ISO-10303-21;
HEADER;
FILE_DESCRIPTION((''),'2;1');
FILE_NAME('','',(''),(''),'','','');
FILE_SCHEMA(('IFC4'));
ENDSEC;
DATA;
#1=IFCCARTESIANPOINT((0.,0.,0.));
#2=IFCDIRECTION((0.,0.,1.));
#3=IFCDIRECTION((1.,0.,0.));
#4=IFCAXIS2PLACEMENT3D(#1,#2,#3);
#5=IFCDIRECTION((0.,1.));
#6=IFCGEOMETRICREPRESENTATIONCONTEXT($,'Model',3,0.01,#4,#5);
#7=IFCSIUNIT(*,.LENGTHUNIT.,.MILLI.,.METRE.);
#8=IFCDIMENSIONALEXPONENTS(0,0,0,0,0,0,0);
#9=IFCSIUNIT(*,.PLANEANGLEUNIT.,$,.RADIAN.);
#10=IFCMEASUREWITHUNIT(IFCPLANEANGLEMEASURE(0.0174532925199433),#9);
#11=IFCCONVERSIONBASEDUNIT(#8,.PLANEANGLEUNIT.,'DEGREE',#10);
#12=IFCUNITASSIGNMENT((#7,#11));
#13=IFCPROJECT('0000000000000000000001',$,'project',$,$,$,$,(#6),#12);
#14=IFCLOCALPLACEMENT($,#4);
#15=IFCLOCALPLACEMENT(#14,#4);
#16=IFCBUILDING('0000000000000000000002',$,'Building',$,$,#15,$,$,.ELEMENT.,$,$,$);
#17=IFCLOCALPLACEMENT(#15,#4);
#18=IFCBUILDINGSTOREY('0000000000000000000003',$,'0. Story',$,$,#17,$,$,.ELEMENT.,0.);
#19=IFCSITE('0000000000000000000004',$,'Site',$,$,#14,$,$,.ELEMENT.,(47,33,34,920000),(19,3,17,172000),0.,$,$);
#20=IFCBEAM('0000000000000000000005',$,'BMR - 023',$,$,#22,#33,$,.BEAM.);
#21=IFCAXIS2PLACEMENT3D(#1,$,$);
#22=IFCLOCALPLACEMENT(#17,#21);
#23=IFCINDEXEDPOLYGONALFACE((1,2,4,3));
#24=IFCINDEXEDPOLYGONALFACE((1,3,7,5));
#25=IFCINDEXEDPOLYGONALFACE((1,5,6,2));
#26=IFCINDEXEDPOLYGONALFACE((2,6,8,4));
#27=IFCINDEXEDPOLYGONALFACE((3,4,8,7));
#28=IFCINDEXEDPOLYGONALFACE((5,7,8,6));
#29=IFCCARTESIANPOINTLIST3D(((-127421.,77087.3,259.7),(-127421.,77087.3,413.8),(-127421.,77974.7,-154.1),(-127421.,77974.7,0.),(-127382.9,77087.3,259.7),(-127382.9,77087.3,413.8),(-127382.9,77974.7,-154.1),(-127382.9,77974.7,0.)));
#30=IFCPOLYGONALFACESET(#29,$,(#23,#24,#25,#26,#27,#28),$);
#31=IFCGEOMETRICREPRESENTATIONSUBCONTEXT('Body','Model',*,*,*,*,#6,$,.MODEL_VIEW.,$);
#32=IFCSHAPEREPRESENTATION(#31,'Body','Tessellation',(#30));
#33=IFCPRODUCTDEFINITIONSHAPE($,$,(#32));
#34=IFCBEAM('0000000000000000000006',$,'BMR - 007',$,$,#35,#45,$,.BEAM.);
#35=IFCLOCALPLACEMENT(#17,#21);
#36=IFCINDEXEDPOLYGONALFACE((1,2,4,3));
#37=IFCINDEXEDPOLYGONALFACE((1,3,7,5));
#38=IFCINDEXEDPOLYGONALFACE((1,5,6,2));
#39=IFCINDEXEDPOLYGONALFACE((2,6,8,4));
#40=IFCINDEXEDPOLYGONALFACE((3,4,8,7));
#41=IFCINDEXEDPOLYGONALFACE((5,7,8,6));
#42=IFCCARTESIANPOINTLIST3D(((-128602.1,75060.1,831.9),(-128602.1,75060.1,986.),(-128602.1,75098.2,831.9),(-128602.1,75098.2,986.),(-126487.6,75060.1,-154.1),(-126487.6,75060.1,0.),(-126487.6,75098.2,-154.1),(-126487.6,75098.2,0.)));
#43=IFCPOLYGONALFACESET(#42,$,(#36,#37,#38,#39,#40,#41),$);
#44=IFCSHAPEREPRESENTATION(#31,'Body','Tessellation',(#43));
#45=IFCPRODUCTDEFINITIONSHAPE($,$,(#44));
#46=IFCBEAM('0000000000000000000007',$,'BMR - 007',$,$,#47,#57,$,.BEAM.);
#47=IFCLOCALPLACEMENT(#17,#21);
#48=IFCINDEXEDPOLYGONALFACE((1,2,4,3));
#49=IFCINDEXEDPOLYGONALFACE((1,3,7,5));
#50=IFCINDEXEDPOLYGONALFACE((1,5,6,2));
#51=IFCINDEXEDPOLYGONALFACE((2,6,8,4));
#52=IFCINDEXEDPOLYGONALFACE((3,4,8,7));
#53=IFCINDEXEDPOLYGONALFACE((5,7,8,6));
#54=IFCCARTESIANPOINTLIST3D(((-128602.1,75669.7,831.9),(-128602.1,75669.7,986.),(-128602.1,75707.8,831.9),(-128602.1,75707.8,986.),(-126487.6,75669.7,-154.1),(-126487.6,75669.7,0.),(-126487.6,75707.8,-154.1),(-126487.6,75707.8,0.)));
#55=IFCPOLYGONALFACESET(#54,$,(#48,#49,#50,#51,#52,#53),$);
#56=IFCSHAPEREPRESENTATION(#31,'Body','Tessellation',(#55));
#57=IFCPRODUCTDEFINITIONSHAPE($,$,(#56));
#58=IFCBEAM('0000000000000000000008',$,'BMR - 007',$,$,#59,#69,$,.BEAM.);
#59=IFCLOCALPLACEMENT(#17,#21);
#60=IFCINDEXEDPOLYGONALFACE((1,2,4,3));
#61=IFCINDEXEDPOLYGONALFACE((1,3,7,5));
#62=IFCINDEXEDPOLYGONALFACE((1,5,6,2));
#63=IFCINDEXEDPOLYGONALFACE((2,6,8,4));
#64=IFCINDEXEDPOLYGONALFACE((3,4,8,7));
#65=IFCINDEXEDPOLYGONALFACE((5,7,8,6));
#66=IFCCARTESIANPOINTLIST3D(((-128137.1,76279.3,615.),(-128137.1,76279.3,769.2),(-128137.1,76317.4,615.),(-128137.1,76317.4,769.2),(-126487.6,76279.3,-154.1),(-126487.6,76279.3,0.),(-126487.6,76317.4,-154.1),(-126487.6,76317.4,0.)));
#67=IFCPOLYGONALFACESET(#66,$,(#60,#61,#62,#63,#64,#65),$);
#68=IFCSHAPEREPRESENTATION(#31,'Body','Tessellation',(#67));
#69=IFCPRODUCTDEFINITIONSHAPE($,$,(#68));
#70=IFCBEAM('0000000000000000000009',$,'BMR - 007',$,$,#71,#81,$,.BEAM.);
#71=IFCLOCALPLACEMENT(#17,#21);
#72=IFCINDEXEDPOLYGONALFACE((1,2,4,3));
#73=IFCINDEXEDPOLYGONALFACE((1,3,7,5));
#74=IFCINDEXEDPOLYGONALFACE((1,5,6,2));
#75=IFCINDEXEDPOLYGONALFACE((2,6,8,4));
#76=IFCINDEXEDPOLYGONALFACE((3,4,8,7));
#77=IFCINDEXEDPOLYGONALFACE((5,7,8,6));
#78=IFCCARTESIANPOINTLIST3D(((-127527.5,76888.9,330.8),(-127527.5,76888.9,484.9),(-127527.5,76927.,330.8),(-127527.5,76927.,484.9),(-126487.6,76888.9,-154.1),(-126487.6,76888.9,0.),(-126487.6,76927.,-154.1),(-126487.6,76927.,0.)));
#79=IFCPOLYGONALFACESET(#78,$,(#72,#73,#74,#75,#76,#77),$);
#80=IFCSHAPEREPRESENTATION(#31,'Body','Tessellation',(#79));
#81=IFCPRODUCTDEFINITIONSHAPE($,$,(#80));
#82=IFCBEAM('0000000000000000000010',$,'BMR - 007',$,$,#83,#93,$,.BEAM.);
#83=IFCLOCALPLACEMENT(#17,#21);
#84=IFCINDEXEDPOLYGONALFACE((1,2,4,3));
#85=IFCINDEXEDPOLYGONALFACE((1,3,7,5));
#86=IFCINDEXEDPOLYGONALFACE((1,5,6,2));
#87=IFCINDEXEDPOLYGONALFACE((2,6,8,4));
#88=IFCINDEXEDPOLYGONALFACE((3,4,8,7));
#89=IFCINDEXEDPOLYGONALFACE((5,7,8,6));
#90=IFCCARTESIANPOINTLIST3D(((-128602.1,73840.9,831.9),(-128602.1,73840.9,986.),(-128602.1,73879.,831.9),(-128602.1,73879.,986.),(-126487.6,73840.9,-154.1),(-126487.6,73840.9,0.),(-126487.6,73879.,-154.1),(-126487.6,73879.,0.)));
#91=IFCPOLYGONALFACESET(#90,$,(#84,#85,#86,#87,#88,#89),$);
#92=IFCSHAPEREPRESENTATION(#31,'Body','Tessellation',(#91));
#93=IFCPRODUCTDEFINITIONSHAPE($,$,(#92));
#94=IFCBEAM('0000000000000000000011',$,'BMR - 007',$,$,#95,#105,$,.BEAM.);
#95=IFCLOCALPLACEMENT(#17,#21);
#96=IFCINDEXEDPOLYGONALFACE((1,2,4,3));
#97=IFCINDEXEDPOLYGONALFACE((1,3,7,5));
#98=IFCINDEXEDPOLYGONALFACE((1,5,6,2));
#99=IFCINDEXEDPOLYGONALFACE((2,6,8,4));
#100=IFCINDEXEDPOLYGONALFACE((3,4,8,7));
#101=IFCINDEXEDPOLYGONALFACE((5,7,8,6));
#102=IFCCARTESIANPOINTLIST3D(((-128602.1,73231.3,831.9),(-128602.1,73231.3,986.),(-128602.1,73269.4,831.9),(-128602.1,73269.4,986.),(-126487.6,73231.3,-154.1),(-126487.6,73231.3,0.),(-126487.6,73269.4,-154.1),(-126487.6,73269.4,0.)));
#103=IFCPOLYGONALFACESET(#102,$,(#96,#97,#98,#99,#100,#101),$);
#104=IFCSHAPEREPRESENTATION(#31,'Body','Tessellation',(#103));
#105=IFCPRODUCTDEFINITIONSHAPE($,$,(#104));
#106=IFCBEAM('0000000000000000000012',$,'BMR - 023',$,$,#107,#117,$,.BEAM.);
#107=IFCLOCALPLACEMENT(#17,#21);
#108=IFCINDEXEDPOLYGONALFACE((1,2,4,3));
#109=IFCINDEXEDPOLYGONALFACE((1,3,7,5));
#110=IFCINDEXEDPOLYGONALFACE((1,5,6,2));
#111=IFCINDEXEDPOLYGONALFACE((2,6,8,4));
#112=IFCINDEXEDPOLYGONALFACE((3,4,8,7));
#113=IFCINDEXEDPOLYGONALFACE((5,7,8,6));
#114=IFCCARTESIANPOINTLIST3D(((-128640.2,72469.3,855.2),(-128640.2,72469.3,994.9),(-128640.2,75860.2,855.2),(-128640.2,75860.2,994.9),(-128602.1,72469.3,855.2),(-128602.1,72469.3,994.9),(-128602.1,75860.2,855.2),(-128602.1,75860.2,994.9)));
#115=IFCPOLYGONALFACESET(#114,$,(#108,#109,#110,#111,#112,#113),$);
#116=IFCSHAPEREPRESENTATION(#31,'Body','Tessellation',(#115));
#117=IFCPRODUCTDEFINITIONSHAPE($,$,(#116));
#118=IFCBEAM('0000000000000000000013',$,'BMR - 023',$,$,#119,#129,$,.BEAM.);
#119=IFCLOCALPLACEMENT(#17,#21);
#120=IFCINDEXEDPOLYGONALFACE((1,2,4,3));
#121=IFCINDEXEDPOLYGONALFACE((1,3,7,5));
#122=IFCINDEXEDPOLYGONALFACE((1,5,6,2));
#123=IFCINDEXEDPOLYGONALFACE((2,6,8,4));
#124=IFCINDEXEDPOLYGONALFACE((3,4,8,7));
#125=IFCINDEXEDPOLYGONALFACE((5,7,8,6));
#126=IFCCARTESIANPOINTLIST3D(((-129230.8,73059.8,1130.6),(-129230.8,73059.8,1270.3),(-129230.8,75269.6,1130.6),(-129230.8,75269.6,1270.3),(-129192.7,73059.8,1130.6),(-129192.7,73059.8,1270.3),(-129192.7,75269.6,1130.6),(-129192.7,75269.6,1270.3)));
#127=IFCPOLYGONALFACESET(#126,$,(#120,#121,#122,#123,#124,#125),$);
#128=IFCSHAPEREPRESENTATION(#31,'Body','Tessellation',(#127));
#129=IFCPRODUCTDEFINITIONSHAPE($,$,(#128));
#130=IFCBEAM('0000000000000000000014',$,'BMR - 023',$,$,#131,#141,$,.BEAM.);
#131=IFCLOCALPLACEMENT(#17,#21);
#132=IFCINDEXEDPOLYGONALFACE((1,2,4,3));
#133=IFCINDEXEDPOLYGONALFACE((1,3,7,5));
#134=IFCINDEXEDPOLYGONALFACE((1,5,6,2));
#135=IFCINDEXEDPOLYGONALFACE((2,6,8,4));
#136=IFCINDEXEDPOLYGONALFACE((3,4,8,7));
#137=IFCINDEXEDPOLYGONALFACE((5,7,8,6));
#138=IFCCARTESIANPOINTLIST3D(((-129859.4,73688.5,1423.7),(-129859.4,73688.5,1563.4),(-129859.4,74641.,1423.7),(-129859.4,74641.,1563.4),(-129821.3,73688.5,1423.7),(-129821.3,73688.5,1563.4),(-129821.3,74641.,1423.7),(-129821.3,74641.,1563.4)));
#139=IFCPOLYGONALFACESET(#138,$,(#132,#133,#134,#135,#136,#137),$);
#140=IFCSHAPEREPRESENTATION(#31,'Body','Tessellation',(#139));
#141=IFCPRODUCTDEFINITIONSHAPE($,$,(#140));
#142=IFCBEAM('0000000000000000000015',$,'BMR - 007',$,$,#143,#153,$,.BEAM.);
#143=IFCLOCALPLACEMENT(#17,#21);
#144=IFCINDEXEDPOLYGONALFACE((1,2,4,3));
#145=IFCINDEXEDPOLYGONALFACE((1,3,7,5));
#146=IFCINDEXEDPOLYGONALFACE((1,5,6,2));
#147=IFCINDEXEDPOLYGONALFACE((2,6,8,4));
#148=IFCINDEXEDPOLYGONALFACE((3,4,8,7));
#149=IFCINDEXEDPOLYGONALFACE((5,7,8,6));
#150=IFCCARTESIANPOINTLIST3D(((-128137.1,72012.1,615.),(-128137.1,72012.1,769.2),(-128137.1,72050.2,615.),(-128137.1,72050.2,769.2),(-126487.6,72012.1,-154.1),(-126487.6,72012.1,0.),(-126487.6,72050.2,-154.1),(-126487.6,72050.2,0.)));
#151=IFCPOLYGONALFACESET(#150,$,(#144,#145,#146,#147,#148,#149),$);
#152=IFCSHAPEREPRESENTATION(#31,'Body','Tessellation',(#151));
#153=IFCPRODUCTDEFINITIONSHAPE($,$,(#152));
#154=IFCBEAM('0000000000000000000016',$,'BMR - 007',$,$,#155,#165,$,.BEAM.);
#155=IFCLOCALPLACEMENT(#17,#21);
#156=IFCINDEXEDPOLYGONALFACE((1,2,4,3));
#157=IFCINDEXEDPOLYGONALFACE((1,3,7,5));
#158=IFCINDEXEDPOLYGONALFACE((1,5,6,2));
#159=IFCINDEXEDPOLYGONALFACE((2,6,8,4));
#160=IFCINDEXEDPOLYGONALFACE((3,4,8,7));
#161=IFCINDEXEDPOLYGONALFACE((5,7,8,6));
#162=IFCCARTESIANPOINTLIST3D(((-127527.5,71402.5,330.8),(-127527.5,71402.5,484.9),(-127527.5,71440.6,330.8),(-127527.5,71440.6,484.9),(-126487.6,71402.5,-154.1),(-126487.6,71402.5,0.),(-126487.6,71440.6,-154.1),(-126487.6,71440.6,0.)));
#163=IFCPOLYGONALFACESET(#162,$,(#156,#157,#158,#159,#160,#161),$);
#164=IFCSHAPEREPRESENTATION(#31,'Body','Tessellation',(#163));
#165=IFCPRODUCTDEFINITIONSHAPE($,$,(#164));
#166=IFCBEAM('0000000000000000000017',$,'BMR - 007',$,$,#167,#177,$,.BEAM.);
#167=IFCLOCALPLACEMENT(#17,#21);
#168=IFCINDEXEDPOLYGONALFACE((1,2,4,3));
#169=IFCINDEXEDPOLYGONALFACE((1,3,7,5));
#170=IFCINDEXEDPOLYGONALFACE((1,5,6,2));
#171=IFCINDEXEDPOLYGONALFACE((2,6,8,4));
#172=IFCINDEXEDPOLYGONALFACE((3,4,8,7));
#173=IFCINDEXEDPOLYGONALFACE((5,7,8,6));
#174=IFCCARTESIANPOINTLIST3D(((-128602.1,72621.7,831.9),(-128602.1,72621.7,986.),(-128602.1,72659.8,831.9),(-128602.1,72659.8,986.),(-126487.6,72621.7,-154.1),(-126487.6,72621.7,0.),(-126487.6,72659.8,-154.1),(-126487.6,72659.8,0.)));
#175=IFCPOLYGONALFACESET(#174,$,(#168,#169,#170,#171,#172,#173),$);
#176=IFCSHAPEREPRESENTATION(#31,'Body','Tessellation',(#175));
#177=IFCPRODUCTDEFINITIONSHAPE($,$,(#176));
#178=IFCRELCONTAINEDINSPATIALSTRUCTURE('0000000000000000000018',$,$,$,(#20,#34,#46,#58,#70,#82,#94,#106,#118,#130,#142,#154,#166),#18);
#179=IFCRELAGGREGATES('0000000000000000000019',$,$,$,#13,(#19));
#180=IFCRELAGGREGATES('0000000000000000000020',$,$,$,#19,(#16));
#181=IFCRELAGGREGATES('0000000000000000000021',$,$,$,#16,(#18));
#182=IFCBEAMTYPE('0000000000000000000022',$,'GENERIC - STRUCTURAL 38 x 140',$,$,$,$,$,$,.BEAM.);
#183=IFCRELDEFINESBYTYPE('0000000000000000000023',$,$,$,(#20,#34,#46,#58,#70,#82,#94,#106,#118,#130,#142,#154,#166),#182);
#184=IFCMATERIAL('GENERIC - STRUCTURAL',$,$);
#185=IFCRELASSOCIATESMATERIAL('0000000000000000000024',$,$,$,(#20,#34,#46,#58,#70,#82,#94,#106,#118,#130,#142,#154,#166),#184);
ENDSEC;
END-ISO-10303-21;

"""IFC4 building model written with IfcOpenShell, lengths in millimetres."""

from ifc_helpers import new_model, entity, si_unit, converted_unit, direction, frame, frame_2d, origin_with_axes, place, context, subcontext, project, spatial, rectangle, extrude, clip, halfspace, material, type_object, element, save


model = new_model("IFC4")

# Units and contexts
model_context = context("Model", 3, precision=0.01, world=origin_with_axes(), true_north=direction((0.0, 1.0)))
body_context = subcontext(model_context, "Body", "Model", "MODEL_VIEW")
ifc_project = project(units=[si_unit("LENGTHUNIT", "METRE", prefix="MILLI"), converted_unit("PLANEANGLEUNIT", "DEGREE", entity("IfcPlaneAngleMeasure", 0.0174532925199433), si_unit("PLANEANGLEUNIT", "RADIAN"), dimensions=[0, 0, 0, 0, 0, 0, 0])], contexts=[model_context])

# Site, building, storey
site_placement = place(None, origin_with_axes())
site = spatial("IfcSite", under=ifc_project, at=site_placement, Name="Site", CompositionType="ELEMENT", RefLatitude=(47, 33, 34, 920000), RefLongitude=(19, 3, 17, 172000), RefElevation=0.0)
building_placement = place(site_placement, origin_with_axes())
building = spatial("IfcBuilding", under=site, at=building_placement, Name="Building", CompositionType="ELEMENT")
storey_placement = place(building_placement, origin_with_axes())
storey = spatial("IfcBuildingStorey", under=building, at=storey_placement, Name="0. Story", CompositionType="ELEMENT", Elevation=0.0)

# Beams
ifc_material = material(Name="GENERIC - STRUCTURAL")
beam_type = type_object("IfcBeamType", Name="GENERIC - STRUCTURAL 38 x 140", PredefinedType="BEAM")
beam_1_placement = place(storey_placement, frame((-127402.0, 77974.7, 0.0), z_axis=(0.0, 0.0, 1.0), x_axis=(-1.0, 0.0, 0.0)))
element("IfcBeam", 1, at=beam_1_placement, inside=storey, type_object=beam_type, material=ifc_material, Name="BMR - 023", PredefinedType="BEAM", context=body_context, shape_type="Clipping", body=[
    clip(clip(extrude(rectangle(XDim=139.7, YDim=38.1, at=frame_2d((-69.8, 0.0), x_axis=(1.0, 0.0))), frame((0.0, -83.5, -38.9), z_axis=(0.0, 0.906308, 0.422618), x_axis=(0.0, -0.422618, 0.906308)), (0.0, 0.0, 1.0), 1163.5), halfspace(frame((0.0, 0.0, 0.0), z_axis=(0.0, 1.0, 0.0), x_axis=(0.0, 0.0, 1.0)), True)), halfspace(frame((0.0, 887.5, 0.0), z_axis=(0.0, -1.0, 0.0), x_axis=(0.0, 0.0, -1.0)), True)),
])
for number, where, z_axis, x_axis, name in (
    (2, (-126487.6, 75079.1, 0.0), (0.0, 0.0, 1.0), (0.0, 1.0, 0.0), "BMR - 007"),
    (3, (-126487.6, 75688.7, 0.0), (0.0, 0.0, 1.0), (0.0, 1.0, 0.0), "BMR - 007"),
):
    element("IfcBeam", number, at=place(storey_placement, frame(where, z_axis=z_axis, x_axis=x_axis)), inside=storey, type_object=beam_type, material=ifc_material, Name=name, PredefinedType="BEAM", context=body_context, shape_type="Clipping", body=[
        clip(clip(extrude(rectangle(XDim=139.7, YDim=38.1, at=frame_2d((-69.8, 0.0), x_axis=(1.0, 0.0))), frame((0.0, -83.5, -38.9), z_axis=(0.0, 0.906308, 0.422618), x_axis=(0.0, -0.422618, 0.906308)), (0.0, 0.0, 1.0), 2517.4), halfspace(frame((0.0, 0.0, 0.0), z_axis=(0.0, 1.0, 0.0), x_axis=(0.0, 0.0, 1.0)), True)), halfspace(frame((0.0, 2114.5, 0.0), z_axis=(0.0, -1.0, 0.0), x_axis=(0.0, 0.0, -1.0)), True)),
    ])
beam_2_placement = place(storey_placement, frame((-126487.6, 76298.3, 0.0), z_axis=(0.0, 0.0, 1.0), x_axis=(0.0, 1.0, 0.0)))
element("IfcBeam", 4, at=beam_2_placement, inside=storey, type_object=beam_type, material=ifc_material, Name="BMR - 007", PredefinedType="BEAM", context=body_context, shape_type="Clipping", body=[
    clip(clip(extrude(rectangle(XDim=139.7, YDim=38.1, at=frame_2d((-69.8, 0.0), x_axis=(1.0, 0.0))), frame((0.0, -83.5, -38.9), z_axis=(0.0, 0.906308, 0.422618), x_axis=(0.0, -0.422618, 0.906308)), (0.0, 0.0, 1.0), 2004.2), halfspace(frame((0.0, 0.0, 0.0), z_axis=(0.0, 1.0, 0.0), x_axis=(0.0, 0.0, 1.0)), True)), halfspace(frame((0.0, 1649.5, 0.0), z_axis=(0.0, -1.0, 0.0), x_axis=(0.0, 0.0, -1.0)), True)),
])
beam_3_placement = place(storey_placement, frame((-126487.6, 76907.9, 0.0), z_axis=(0.0, 0.0, 1.0), x_axis=(0.0, 1.0, 0.0)))
element("IfcBeam", 5, at=beam_3_placement, inside=storey, type_object=beam_type, material=ifc_material, Name="BMR - 007", PredefinedType="BEAM", context=body_context, shape_type="Clipping", body=[
    clip(clip(extrude(rectangle(XDim=139.7, YDim=38.1, at=frame_2d((-69.8, 0.0), x_axis=(1.0, 0.0))), frame((0.0, -83.5, -38.9), z_axis=(0.0, 0.906308, 0.422618), x_axis=(0.0, -0.422618, 0.906308)), (0.0, 0.0, 1.0), 1331.6), halfspace(frame((0.0, 0.0, 0.0), z_axis=(0.0, 1.0, 0.0), x_axis=(0.0, 0.0, 1.0)), True)), halfspace(frame((0.0, 1039.9, 0.0), z_axis=(0.0, -1.0, 0.0), x_axis=(0.0, 0.0, -1.0)), True)),
])
for number, where, z_axis, x_axis, name in (
    (6, (-126487.6, 73859.9, 0.0), (0.0, 0.0, 1.0), (0.0, 1.0, 0.0), "BMR - 007"),
    (7, (-126487.6, 73250.3, 0.0), (0.0, 0.0, 1.0), (0.0, 1.0, 0.0), "BMR - 007"),
):
    element("IfcBeam", number, at=place(storey_placement, frame(where, z_axis=z_axis, x_axis=x_axis)), inside=storey, type_object=beam_type, material=ifc_material, Name=name, PredefinedType="BEAM", context=body_context, shape_type="Clipping", body=[
        clip(clip(extrude(rectangle(XDim=139.7, YDim=38.1, at=frame_2d((-69.8, 0.0), x_axis=(1.0, 0.0))), frame((0.0, -83.5, -38.9), z_axis=(0.0, 0.906308, 0.422618), x_axis=(0.0, -0.422618, 0.906308)), (0.0, 0.0, 1.0), 2517.4), halfspace(frame((0.0, 0.0, 0.0), z_axis=(0.0, 1.0, 0.0), x_axis=(0.0, 0.0, 1.0)), True)), halfspace(frame((0.0, 2114.5, 0.0), z_axis=(0.0, -1.0, 0.0), x_axis=(0.0, 0.0, -1.0)), True)),
    ])
beam_4_placement = place(storey_placement, frame((-128621.2, 75860.2, 994.9), z_axis=(0.0, 0.0, 1.0), x_axis=(-1.0, 0.0, 0.0)))
element("IfcBeam", 8, at=beam_4_placement, inside=storey, type_object=beam_type, material=ifc_material, Name="BMR - 023", PredefinedType="BEAM", context=body_context, shape_type="SweptSolid", body=[
    extrude(rectangle(XDim=139.7, YDim=38.1, at=frame_2d((-69.8, 0.0), x_axis=(1.0, 0.0))), frame((0.0, 0.0, 0.0), z_axis=(0.0, 1.0, 0.0), x_axis=(0.0, 0.0, 1.0)), (0.0, 0.0, 1.0), 3390.9),
])
beam_5_placement = place(storey_placement, frame((-129211.7, 75269.6, 1270.3), z_axis=(0.0, 0.0, 1.0), x_axis=(-1.0, 0.0, 0.0)))
element("IfcBeam", 9, at=beam_5_placement, inside=storey, type_object=beam_type, material=ifc_material, Name="BMR - 023", PredefinedType="BEAM", context=body_context, shape_type="SweptSolid", body=[
    extrude(rectangle(XDim=139.7, YDim=38.1, at=frame_2d((-69.8, 0.0), x_axis=(1.0, 0.0))), frame((0.0, 0.0, 0.0), z_axis=(0.0, 1.0, 0.0), x_axis=(0.0, 0.0, 1.0)), (0.0, 0.0, 1.0), 2209.8),
])
beam_6_placement = place(storey_placement, frame((-129840.4, 74641.0, 1563.4), z_axis=(0.0, 0.0, 1.0), x_axis=(-1.0, 0.0, 0.0)))
element("IfcBeam", 10, at=beam_6_placement, inside=storey, type_object=beam_type, material=ifc_material, Name="BMR - 023", PredefinedType="BEAM", context=body_context, shape_type="SweptSolid", body=[
    extrude(rectangle(XDim=139.7, YDim=38.1, at=frame_2d((-69.8, 0.0), x_axis=(1.0, 0.0))), frame((0.0, 0.0, 0.0), z_axis=(0.0, 1.0, 0.0), x_axis=(0.0, 0.0, 1.0)), (0.0, 0.0, 1.0), 952.5),
])
beam_7_placement = place(storey_placement, frame((-126487.6, 72031.1, 0.0), z_axis=(0.0, 0.0, 1.0), x_axis=(0.0, 1.0, 0.0)))
element("IfcBeam", 11, at=beam_7_placement, inside=storey, type_object=beam_type, material=ifc_material, Name="BMR - 007", PredefinedType="BEAM", context=body_context, shape_type="Clipping", body=[
    clip(clip(extrude(rectangle(XDim=139.7, YDim=38.1, at=frame_2d((-69.8, 0.0), x_axis=(1.0, 0.0))), frame((0.0, -83.5, -38.9), z_axis=(0.0, 0.906308, 0.422618), x_axis=(0.0, -0.422618, 0.906308)), (0.0, 0.0, 1.0), 2004.2), halfspace(frame((0.0, 0.0, 0.0), z_axis=(0.0, 1.0, 0.0), x_axis=(0.0, 0.0, 1.0)), True)), halfspace(frame((0.0, 1649.5, 0.0), z_axis=(0.0, -1.0, 0.0), x_axis=(0.0, 0.0, -1.0)), True)),
])
beam_8_placement = place(storey_placement, frame((-126487.6, 71421.5, 0.0), z_axis=(0.0, 0.0, 1.0), x_axis=(0.0, 1.0, 0.0)))
element("IfcBeam", 12, at=beam_8_placement, inside=storey, type_object=beam_type, material=ifc_material, Name="BMR - 007", PredefinedType="BEAM", context=body_context, shape_type="Clipping", body=[
    clip(clip(extrude(rectangle(XDim=139.7, YDim=38.1, at=frame_2d((-69.8, 0.0), x_axis=(1.0, 0.0))), frame((0.0, -83.5, -38.9), z_axis=(0.0, 0.906308, 0.422618), x_axis=(0.0, -0.422618, 0.906308)), (0.0, 0.0, 1.0), 1331.6), halfspace(frame((0.0, 0.0, 0.0), z_axis=(0.0, 1.0, 0.0), x_axis=(0.0, 0.0, 1.0)), True)), halfspace(frame((0.0, 1039.9, 0.0), z_axis=(0.0, -1.0, 0.0), x_axis=(0.0, 0.0, -1.0)), True)),
])
beam_9_placement = place(storey_placement, frame((-126487.6, 72640.7, 0.0), z_axis=(0.0, 0.0, 1.0), x_axis=(0.0, 1.0, 0.0)))
element("IfcBeam", 13, at=beam_9_placement, inside=storey, type_object=beam_type, material=ifc_material, Name="BMR - 007", PredefinedType="BEAM", context=body_context, shape_type="Clipping", body=[
    clip(clip(extrude(rectangle(XDim=139.7, YDim=38.1, at=frame_2d((-69.8, 0.0), x_axis=(1.0, 0.0))), frame((0.0, -83.5, -38.9), z_axis=(0.0, 0.906308, 0.422618), x_axis=(0.0, -0.422618, 0.906308)), (0.0, 0.0, 1.0), 2517.4), halfspace(frame((0.0, 0.0, 0.0), z_axis=(0.0, 1.0, 0.0), x_axis=(0.0, 0.0, 1.0)), True)), halfspace(frame((0.0, 2114.5, 0.0), z_axis=(0.0, -1.0, 0.0), x_axis=(0.0, 0.0, -1.0)), True)),
])

save(model, "model.ifc")
